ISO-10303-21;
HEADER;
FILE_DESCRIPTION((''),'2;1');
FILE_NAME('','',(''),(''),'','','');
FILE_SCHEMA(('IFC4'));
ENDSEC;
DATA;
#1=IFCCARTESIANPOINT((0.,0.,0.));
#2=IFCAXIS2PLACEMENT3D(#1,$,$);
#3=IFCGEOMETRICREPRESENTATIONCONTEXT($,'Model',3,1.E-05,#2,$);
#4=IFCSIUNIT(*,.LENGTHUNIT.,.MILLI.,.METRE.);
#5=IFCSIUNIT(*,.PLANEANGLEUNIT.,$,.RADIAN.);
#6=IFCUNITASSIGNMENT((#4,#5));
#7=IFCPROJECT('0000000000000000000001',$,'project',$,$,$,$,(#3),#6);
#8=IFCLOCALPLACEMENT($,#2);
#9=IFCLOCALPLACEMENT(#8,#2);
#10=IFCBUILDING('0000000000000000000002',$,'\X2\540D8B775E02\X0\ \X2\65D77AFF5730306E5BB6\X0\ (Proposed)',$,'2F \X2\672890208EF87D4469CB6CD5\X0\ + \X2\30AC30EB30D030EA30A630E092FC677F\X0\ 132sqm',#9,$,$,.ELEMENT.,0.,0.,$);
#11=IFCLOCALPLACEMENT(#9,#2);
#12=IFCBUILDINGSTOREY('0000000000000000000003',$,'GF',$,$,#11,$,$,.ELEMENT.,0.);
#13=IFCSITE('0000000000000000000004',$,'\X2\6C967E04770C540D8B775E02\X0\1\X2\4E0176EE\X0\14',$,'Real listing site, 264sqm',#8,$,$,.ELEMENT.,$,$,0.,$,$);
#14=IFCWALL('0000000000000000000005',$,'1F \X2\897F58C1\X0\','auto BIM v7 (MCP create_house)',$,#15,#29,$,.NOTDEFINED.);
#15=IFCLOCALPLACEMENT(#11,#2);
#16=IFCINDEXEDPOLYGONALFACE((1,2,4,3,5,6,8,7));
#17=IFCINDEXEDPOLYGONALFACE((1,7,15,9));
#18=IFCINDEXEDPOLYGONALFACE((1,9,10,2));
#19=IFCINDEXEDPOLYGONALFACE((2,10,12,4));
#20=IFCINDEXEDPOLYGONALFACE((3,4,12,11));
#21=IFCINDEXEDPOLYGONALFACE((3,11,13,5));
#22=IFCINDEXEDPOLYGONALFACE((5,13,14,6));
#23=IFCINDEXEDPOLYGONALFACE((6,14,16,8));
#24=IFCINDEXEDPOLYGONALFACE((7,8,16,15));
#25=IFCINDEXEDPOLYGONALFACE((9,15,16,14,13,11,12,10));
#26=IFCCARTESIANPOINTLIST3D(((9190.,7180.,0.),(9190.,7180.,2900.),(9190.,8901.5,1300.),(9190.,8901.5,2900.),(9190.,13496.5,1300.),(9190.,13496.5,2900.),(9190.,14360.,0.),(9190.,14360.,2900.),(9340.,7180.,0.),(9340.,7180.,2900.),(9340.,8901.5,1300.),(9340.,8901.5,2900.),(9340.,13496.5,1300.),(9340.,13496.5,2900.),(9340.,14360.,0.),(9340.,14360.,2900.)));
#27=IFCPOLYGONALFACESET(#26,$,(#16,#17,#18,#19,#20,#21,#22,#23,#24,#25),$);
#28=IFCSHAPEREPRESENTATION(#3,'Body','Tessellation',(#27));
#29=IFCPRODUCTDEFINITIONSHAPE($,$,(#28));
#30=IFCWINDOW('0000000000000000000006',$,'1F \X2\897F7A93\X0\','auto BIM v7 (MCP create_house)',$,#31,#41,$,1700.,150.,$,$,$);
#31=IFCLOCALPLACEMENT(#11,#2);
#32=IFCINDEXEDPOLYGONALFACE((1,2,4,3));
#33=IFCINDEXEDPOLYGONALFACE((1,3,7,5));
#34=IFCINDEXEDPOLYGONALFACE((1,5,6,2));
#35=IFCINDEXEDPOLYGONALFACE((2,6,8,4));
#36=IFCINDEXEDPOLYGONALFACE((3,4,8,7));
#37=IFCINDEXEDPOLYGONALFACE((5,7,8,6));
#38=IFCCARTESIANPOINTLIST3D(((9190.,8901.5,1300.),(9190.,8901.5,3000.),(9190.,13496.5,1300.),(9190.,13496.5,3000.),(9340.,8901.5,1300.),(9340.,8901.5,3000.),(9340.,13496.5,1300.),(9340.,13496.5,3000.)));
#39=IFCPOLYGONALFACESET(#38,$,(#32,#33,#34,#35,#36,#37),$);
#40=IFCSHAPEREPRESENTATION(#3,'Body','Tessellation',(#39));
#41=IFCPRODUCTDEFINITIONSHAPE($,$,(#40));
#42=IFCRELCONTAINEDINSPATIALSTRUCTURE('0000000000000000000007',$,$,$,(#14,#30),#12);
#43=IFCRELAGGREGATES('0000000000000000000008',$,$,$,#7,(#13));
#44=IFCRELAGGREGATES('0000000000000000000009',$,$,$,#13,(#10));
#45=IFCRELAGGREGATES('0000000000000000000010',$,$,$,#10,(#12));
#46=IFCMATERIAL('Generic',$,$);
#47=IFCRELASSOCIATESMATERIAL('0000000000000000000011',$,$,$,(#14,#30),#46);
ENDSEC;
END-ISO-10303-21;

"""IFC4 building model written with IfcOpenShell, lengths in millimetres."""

from ifc_helpers import new_model, si_unit, frame, frame_2d, origin, place, context, project, spatial, rectangle, extrude, material, element, fill, save


model = new_model("IFC4")

# Units and contexts
model_context = context("Model", 3, precision=1e-05, world=origin())
ifc_project = project(units=[si_unit("LENGTHUNIT", "METRE", prefix="MILLI"), si_unit("PLANEANGLEUNIT", "RADIAN")], contexts=[model_context])

# Site, building, storey
site_placement = place(None, origin())
site = spatial("IfcSite", under=ifc_project, at=site_placement, Name="沖縄県名護市1丁目14", ObjectType="Real listing site, 264sqm", CompositionType="ELEMENT", RefElevation=0.0)
building_placement = place(site_placement, origin())
building = spatial("IfcBuilding", under=site, at=building_placement, Name="名護市 旗竿地の家 (Proposed)", ObjectType="2F 木造軸組構法 + ガルバリウム鋼板 132sqm", CompositionType="ELEMENT", ElevationOfRefHeight=0.0, ElevationOfTerrain=0.0)
storey_placement = place(building_placement, origin())
storey = spatial("IfcBuildingStorey", under=building, at=storey_placement, Name="GF", CompositionType="ELEMENT", Elevation=0.0)

# Shared definitions
ifc_material = material(Name="Generic")

# Wall, opening, window
wall_1_placement = place(storey_placement, frame((4595.0, 3590.0, 0.0)))
wall_1 = element("IfcWall", 1, at=wall_1_placement, inside=storey, material=ifc_material, Name="1F 西壁", Description="auto BIM v7 (MCP create_house)", PredefinedType="NOTDEFINED", context=model_context, shape_type="SweptSolid", body=[
    extrude(rectangle(XDim=150.0, YDim=7180.0, at=frame_2d((75.0, 3590.0))), frame((4595.0, 3590.0, 0.0)), (0.0, 0.0, 1.0), 2900.0),
])
opening_1_placement = place(storey_placement, frame((4595.0, 4451.0, 650.0)))
opening_1 = element("IfcOpeningElement", 2, at=opening_1_placement, cuts=wall_1, PredefinedType="NOTDEFINED", context=model_context, shape_type="SweptSolid", body=[
    extrude(rectangle(XDim=150.0, YDim=4595.0, at=frame_2d((75.0, 2297.0))), frame((4595.0, 4451.0, 650.0)), (0.0, 0.0, 1.0), 1700.0),
])
window_1_placement = place(storey_placement, frame((4595.0, 4451.0, 650.0)))
window_1 = element("IfcWindow", 3, at=window_1_placement, inside=storey, material=ifc_material, Name="1F 西窓", Description="auto BIM v7 (MCP create_house)", OverallHeight=1700.0, OverallWidth=150.0, context=model_context, shape_type="SweptSolid", body=[
    extrude(rectangle(XDim=150.0, YDim=4595.0, at=frame_2d((75.0, 2297.0))), frame((4595.0, 4451.0, 650.0)), (0.0, 0.0, 1.0), 1700.0),
])
fill(opening_1, window_1)

save(model, "model.ifc")
